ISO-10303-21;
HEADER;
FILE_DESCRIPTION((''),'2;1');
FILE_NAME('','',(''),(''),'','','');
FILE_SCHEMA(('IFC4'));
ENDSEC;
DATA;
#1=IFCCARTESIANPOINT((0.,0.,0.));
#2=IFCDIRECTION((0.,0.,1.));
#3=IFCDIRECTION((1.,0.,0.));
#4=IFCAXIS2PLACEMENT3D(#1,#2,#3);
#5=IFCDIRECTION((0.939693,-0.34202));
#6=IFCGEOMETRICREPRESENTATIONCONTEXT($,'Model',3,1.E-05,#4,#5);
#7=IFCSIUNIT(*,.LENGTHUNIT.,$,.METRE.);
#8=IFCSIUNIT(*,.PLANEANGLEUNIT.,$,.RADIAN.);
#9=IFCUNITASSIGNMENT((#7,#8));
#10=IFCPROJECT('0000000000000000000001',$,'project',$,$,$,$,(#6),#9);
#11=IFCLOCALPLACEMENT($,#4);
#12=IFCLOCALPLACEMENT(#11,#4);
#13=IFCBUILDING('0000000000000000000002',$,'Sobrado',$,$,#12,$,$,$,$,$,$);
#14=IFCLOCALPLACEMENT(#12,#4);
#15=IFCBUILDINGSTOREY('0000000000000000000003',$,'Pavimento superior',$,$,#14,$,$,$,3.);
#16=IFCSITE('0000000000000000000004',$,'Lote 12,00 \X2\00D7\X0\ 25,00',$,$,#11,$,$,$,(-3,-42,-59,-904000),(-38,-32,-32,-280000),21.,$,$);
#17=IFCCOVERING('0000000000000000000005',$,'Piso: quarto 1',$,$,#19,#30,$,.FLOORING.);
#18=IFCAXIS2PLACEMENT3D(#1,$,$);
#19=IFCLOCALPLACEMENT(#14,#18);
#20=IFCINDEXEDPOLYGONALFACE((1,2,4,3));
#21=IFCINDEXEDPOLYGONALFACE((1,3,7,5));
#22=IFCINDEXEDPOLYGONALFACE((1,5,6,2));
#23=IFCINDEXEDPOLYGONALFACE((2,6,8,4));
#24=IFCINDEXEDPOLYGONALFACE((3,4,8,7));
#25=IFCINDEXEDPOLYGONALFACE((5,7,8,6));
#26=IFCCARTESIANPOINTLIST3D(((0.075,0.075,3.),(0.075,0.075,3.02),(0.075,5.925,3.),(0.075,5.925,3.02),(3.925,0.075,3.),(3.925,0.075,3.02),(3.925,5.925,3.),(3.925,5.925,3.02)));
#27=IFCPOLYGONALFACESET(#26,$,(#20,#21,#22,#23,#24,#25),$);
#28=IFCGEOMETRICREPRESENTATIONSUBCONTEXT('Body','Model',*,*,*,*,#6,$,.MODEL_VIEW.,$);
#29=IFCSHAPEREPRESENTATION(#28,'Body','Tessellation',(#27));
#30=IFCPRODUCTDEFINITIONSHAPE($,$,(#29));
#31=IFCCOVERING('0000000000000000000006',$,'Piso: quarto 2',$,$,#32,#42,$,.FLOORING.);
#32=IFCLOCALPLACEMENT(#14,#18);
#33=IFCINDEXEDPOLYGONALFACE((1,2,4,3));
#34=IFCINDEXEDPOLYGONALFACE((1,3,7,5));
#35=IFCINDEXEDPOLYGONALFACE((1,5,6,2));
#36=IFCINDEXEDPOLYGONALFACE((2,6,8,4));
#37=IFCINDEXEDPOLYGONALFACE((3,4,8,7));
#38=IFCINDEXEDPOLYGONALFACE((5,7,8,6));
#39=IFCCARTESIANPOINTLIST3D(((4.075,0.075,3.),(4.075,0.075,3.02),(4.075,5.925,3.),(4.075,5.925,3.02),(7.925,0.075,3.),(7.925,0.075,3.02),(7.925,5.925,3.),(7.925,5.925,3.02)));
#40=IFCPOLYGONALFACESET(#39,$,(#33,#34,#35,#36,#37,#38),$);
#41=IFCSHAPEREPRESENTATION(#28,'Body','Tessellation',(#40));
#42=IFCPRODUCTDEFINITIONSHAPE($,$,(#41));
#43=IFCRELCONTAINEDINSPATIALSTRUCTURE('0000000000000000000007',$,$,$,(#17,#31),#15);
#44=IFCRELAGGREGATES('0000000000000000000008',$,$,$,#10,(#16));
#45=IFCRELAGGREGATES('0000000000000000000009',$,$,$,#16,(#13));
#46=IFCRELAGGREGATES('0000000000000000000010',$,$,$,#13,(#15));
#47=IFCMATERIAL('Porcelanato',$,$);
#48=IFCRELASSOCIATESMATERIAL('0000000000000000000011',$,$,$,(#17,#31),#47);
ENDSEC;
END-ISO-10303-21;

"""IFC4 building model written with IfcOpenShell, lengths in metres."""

from ifc_helpers import new_model, si_unit, direction, frame, origin_with_axes, place, context, subcontext, project, spatial, line, indexed_curve, outline, extrude, material, element, save


model = new_model("IFC4")

# Units and contexts
model_context = context("Model", 3, precision=1e-05, world=origin_with_axes(), true_north=direction((0.939693, -0.34202)))
body_context = subcontext(model_context, "Body", "Model", "MODEL_VIEW")
ifc_project = project(units=[si_unit("LENGTHUNIT", "METRE"), si_unit("PLANEANGLEUNIT", "RADIAN")], contexts=[model_context])

# Site, building, storey
site_placement = place(None, origin_with_axes())
site = spatial("IfcSite", under=ifc_project, at=site_placement, Name="Lote 12,00 × 25,00", RefLatitude=(-3, -42, -59, -904000), RefLongitude=(-38, -32, -32, -280000), RefElevation=21.0)
building_placement = place(site_placement, origin_with_axes())
building = spatial("IfcBuilding", under=site, at=building_placement, Name="Sobrado")
storey_placement = place(building_placement, origin_with_axes())
storey = spatial("IfcBuildingStorey", under=building, at=storey_placement, Name="Pavimento superior", Elevation=3.0)

# Coverings
ifc_material_1 = material(Name="Porcelanato")
covering_1_placement = place(storey_placement, origin_with_axes())
element("IfcCovering", 1, at=covering_1_placement, inside=storey, material=ifc_material_1, Name="Piso: quarto 1", PredefinedType="FLOORING", context=body_context, shape_type="SweptSolid", body=[
    extrude(outline(indexed_curve([(0.075, 0.075), (3.925, 0.075), (3.925, 5.925), (0.075, 5.925)], segments=[line(1, 2, 3, 4, 1)])), frame((0.0, 0.0, 3.0), z_axis=(0.0, 0.0, 1.0), x_axis=(1.0, 0.0, 0.0)), (0.0, 0.0, 1.0), 0.02),
])
covering_2_placement = place(storey_placement, origin_with_axes())
element("IfcCovering", 2, at=covering_2_placement, inside=storey, material=ifc_material_1, Name="Piso: quarto 2", PredefinedType="FLOORING", context=body_context, shape_type="SweptSolid", body=[
    extrude(outline(indexed_curve([(4.075, 0.075), (7.925, 0.075), (7.925, 5.925), (4.075, 5.925)], segments=[line(1, 2, 3, 4, 1)])), frame((0.0, 0.0, 3.0), z_axis=(0.0, 0.0, 1.0), x_axis=(1.0, 0.0, 0.0)), (0.0, 0.0, 1.0), 0.02),
])

save(model, "model.ifc")
